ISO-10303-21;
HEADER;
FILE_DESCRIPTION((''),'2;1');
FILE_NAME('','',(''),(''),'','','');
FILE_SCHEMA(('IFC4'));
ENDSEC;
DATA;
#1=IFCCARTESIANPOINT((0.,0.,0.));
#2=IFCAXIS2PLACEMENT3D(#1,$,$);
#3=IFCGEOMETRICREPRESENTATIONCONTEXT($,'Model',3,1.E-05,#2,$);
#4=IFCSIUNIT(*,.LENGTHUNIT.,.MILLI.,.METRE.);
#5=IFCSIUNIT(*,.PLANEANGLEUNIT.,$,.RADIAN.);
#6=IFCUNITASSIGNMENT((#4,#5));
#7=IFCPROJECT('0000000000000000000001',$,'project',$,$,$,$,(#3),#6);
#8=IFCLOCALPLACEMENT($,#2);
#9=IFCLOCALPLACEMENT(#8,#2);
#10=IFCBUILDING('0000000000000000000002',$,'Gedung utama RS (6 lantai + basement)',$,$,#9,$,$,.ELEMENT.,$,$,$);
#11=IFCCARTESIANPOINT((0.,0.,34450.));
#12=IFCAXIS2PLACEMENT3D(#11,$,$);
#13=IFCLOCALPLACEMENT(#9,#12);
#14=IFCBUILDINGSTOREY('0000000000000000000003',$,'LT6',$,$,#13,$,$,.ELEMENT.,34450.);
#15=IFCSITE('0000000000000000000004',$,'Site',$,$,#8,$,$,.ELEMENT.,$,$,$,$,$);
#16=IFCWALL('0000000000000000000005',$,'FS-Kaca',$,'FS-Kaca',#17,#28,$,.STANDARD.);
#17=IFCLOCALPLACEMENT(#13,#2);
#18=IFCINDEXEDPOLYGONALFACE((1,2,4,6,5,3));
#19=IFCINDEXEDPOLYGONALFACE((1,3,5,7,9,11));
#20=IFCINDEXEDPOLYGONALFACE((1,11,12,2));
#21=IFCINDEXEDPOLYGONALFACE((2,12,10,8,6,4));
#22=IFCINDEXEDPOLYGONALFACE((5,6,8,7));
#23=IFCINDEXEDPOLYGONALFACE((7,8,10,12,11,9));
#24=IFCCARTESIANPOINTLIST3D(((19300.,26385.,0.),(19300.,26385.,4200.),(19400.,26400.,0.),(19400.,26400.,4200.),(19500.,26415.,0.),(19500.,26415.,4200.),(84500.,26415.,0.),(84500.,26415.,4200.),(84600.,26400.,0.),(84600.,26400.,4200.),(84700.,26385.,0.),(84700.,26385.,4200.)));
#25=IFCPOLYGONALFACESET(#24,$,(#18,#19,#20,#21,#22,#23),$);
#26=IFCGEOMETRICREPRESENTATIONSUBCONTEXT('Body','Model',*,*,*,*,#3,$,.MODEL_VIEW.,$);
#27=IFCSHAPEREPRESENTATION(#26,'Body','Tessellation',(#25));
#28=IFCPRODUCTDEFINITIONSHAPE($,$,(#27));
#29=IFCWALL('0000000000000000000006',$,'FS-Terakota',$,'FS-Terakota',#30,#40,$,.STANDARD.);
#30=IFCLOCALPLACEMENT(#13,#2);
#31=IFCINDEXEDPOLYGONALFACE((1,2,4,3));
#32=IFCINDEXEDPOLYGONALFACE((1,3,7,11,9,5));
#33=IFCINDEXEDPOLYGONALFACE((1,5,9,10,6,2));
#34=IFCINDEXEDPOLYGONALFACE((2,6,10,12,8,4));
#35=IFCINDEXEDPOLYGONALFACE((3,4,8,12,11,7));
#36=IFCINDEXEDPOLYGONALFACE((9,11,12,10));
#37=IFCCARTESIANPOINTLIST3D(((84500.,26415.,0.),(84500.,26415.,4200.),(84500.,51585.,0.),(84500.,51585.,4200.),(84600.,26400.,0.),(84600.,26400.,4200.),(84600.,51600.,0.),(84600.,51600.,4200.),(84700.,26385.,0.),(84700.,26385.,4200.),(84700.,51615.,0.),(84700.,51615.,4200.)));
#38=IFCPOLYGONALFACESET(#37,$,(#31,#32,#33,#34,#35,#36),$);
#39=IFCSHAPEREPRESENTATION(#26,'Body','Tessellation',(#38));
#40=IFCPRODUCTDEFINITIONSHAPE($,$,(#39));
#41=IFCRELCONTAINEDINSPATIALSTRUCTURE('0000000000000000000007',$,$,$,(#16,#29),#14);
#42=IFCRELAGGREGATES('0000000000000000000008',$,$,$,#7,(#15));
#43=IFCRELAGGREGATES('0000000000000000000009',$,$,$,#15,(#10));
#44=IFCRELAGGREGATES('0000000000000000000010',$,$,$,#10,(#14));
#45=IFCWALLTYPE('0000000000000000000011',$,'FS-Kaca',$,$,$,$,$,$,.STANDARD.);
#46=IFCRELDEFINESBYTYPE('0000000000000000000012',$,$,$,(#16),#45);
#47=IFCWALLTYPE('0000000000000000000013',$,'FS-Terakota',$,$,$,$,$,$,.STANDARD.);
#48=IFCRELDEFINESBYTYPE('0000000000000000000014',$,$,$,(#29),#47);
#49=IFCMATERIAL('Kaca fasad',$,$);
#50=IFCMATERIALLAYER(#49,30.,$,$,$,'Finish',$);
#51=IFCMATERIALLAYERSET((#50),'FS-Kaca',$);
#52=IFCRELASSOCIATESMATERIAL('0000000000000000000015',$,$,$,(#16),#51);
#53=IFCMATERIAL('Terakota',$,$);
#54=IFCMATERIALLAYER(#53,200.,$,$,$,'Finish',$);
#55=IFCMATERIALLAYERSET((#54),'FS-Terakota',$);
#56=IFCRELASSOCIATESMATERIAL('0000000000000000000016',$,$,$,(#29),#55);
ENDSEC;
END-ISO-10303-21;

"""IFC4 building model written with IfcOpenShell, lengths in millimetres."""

from ifc_helpers import new_model, si_unit, frame, origin, place, context, subcontext, project, spatial, polyline, outline, extrude, material, layer, layer_set, layer_usage, type_object, element, save


model = new_model("IFC4")

# Units and contexts
model_context = context("Model", 3, precision=1e-05, world=origin())
body_context = subcontext(model_context, "Body", "Model", "MODEL_VIEW")
ifc_project = project(units=[si_unit("LENGTHUNIT", "METRE", prefix="MILLI"), si_unit("PLANEANGLEUNIT", "RADIAN")], contexts=[model_context])

# Site, building, storey
site_placement = place(None, origin())
site = spatial("IfcSite", under=ifc_project, at=site_placement, Name="Site", CompositionType="ELEMENT")
building_placement = place(site_placement, origin())
building = spatial("IfcBuilding", under=site, at=building_placement, Name="Gedung utama RS (6 lantai + basement)", CompositionType="ELEMENT")
storey_placement = place(building_placement, frame((0.0, 0.0, 34450.0)))
storey = spatial("IfcBuildingStorey", under=building, at=storey_placement, Name="LT6", CompositionType="ELEMENT", Elevation=34450.0)

# Walls
ifc_material_1 = material(Name="Kaca fasad")
ifc_layer_1 = layer(ifc_material_1, 30.0, Category="Finish")
ifc_layer_set_1 = layer_set([ifc_layer_1], Name="FS-Kaca")
ifc_layer_usage_1 = layer_usage(ifc_layer_set_1, "AXIS2", "NEGATIVE", 15.0)
wall_type_1 = type_object("IfcWallType", Name="FS-Kaca", PredefinedType="STANDARD")
wall_1_placement = place(storey_placement, frame((84600.0, 26400.0, 0.0), z_axis=(0.0, 0.0, 1.0), x_axis=(-1.0, 0.0, 0.0)))
element("IfcWall", 1, at=wall_1_placement, inside=storey, type_object=wall_type_1, material=ifc_layer_usage_1, Name="FS-Kaca", ObjectType="FS-Kaca", PredefinedType="STANDARD", context=body_context, shape_type="SweptSolid", body=[
    extrude(outline(polyline([(100.0, -15.0), (0.0, 0.0), (-100.0, 15.0), (65300.0, 15.0), (65200.0, 0.0), (65100.0, -15.0), (100.0, -15.0)])), origin(), (0.0, 0.0, 1.0), 4200.0),
])
ifc_material_2 = material(Name="Terakota")
ifc_layer_2 = layer(ifc_material_2, 200.0, Category="Finish")
ifc_layer_set_2 = layer_set([ifc_layer_2], Name="FS-Terakota")
ifc_layer_usage_2 = layer_usage(ifc_layer_set_2, "AXIS2", "NEGATIVE", 100.0)
wall_type_2 = type_object("IfcWallType", Name="FS-Terakota", PredefinedType="STANDARD")
wall_2_placement = place(storey_placement, frame((84600.0, 51600.0, 0.0), z_axis=(0.0, 0.0, 1.0), x_axis=(0.0, -1.0, 0.0)))
element("IfcWall", 2, at=wall_2_placement, inside=storey, type_object=wall_type_2, material=ifc_layer_usage_2, Name="FS-Terakota", ObjectType="FS-Terakota", PredefinedType="STANDARD", context=body_context, shape_type="SweptSolid", body=[
    extrude(outline(polyline([(15.0, -100.0), (0.0, 0.0), (-15.0, 100.0), (25215.0, 100.0), (25200.0, 0.0), (25185.0, -100.0), (15.0, -100.0)])), origin(), (0.0, 0.0, 1.0), 4200.0),
])

save(model, "model.ifc")
